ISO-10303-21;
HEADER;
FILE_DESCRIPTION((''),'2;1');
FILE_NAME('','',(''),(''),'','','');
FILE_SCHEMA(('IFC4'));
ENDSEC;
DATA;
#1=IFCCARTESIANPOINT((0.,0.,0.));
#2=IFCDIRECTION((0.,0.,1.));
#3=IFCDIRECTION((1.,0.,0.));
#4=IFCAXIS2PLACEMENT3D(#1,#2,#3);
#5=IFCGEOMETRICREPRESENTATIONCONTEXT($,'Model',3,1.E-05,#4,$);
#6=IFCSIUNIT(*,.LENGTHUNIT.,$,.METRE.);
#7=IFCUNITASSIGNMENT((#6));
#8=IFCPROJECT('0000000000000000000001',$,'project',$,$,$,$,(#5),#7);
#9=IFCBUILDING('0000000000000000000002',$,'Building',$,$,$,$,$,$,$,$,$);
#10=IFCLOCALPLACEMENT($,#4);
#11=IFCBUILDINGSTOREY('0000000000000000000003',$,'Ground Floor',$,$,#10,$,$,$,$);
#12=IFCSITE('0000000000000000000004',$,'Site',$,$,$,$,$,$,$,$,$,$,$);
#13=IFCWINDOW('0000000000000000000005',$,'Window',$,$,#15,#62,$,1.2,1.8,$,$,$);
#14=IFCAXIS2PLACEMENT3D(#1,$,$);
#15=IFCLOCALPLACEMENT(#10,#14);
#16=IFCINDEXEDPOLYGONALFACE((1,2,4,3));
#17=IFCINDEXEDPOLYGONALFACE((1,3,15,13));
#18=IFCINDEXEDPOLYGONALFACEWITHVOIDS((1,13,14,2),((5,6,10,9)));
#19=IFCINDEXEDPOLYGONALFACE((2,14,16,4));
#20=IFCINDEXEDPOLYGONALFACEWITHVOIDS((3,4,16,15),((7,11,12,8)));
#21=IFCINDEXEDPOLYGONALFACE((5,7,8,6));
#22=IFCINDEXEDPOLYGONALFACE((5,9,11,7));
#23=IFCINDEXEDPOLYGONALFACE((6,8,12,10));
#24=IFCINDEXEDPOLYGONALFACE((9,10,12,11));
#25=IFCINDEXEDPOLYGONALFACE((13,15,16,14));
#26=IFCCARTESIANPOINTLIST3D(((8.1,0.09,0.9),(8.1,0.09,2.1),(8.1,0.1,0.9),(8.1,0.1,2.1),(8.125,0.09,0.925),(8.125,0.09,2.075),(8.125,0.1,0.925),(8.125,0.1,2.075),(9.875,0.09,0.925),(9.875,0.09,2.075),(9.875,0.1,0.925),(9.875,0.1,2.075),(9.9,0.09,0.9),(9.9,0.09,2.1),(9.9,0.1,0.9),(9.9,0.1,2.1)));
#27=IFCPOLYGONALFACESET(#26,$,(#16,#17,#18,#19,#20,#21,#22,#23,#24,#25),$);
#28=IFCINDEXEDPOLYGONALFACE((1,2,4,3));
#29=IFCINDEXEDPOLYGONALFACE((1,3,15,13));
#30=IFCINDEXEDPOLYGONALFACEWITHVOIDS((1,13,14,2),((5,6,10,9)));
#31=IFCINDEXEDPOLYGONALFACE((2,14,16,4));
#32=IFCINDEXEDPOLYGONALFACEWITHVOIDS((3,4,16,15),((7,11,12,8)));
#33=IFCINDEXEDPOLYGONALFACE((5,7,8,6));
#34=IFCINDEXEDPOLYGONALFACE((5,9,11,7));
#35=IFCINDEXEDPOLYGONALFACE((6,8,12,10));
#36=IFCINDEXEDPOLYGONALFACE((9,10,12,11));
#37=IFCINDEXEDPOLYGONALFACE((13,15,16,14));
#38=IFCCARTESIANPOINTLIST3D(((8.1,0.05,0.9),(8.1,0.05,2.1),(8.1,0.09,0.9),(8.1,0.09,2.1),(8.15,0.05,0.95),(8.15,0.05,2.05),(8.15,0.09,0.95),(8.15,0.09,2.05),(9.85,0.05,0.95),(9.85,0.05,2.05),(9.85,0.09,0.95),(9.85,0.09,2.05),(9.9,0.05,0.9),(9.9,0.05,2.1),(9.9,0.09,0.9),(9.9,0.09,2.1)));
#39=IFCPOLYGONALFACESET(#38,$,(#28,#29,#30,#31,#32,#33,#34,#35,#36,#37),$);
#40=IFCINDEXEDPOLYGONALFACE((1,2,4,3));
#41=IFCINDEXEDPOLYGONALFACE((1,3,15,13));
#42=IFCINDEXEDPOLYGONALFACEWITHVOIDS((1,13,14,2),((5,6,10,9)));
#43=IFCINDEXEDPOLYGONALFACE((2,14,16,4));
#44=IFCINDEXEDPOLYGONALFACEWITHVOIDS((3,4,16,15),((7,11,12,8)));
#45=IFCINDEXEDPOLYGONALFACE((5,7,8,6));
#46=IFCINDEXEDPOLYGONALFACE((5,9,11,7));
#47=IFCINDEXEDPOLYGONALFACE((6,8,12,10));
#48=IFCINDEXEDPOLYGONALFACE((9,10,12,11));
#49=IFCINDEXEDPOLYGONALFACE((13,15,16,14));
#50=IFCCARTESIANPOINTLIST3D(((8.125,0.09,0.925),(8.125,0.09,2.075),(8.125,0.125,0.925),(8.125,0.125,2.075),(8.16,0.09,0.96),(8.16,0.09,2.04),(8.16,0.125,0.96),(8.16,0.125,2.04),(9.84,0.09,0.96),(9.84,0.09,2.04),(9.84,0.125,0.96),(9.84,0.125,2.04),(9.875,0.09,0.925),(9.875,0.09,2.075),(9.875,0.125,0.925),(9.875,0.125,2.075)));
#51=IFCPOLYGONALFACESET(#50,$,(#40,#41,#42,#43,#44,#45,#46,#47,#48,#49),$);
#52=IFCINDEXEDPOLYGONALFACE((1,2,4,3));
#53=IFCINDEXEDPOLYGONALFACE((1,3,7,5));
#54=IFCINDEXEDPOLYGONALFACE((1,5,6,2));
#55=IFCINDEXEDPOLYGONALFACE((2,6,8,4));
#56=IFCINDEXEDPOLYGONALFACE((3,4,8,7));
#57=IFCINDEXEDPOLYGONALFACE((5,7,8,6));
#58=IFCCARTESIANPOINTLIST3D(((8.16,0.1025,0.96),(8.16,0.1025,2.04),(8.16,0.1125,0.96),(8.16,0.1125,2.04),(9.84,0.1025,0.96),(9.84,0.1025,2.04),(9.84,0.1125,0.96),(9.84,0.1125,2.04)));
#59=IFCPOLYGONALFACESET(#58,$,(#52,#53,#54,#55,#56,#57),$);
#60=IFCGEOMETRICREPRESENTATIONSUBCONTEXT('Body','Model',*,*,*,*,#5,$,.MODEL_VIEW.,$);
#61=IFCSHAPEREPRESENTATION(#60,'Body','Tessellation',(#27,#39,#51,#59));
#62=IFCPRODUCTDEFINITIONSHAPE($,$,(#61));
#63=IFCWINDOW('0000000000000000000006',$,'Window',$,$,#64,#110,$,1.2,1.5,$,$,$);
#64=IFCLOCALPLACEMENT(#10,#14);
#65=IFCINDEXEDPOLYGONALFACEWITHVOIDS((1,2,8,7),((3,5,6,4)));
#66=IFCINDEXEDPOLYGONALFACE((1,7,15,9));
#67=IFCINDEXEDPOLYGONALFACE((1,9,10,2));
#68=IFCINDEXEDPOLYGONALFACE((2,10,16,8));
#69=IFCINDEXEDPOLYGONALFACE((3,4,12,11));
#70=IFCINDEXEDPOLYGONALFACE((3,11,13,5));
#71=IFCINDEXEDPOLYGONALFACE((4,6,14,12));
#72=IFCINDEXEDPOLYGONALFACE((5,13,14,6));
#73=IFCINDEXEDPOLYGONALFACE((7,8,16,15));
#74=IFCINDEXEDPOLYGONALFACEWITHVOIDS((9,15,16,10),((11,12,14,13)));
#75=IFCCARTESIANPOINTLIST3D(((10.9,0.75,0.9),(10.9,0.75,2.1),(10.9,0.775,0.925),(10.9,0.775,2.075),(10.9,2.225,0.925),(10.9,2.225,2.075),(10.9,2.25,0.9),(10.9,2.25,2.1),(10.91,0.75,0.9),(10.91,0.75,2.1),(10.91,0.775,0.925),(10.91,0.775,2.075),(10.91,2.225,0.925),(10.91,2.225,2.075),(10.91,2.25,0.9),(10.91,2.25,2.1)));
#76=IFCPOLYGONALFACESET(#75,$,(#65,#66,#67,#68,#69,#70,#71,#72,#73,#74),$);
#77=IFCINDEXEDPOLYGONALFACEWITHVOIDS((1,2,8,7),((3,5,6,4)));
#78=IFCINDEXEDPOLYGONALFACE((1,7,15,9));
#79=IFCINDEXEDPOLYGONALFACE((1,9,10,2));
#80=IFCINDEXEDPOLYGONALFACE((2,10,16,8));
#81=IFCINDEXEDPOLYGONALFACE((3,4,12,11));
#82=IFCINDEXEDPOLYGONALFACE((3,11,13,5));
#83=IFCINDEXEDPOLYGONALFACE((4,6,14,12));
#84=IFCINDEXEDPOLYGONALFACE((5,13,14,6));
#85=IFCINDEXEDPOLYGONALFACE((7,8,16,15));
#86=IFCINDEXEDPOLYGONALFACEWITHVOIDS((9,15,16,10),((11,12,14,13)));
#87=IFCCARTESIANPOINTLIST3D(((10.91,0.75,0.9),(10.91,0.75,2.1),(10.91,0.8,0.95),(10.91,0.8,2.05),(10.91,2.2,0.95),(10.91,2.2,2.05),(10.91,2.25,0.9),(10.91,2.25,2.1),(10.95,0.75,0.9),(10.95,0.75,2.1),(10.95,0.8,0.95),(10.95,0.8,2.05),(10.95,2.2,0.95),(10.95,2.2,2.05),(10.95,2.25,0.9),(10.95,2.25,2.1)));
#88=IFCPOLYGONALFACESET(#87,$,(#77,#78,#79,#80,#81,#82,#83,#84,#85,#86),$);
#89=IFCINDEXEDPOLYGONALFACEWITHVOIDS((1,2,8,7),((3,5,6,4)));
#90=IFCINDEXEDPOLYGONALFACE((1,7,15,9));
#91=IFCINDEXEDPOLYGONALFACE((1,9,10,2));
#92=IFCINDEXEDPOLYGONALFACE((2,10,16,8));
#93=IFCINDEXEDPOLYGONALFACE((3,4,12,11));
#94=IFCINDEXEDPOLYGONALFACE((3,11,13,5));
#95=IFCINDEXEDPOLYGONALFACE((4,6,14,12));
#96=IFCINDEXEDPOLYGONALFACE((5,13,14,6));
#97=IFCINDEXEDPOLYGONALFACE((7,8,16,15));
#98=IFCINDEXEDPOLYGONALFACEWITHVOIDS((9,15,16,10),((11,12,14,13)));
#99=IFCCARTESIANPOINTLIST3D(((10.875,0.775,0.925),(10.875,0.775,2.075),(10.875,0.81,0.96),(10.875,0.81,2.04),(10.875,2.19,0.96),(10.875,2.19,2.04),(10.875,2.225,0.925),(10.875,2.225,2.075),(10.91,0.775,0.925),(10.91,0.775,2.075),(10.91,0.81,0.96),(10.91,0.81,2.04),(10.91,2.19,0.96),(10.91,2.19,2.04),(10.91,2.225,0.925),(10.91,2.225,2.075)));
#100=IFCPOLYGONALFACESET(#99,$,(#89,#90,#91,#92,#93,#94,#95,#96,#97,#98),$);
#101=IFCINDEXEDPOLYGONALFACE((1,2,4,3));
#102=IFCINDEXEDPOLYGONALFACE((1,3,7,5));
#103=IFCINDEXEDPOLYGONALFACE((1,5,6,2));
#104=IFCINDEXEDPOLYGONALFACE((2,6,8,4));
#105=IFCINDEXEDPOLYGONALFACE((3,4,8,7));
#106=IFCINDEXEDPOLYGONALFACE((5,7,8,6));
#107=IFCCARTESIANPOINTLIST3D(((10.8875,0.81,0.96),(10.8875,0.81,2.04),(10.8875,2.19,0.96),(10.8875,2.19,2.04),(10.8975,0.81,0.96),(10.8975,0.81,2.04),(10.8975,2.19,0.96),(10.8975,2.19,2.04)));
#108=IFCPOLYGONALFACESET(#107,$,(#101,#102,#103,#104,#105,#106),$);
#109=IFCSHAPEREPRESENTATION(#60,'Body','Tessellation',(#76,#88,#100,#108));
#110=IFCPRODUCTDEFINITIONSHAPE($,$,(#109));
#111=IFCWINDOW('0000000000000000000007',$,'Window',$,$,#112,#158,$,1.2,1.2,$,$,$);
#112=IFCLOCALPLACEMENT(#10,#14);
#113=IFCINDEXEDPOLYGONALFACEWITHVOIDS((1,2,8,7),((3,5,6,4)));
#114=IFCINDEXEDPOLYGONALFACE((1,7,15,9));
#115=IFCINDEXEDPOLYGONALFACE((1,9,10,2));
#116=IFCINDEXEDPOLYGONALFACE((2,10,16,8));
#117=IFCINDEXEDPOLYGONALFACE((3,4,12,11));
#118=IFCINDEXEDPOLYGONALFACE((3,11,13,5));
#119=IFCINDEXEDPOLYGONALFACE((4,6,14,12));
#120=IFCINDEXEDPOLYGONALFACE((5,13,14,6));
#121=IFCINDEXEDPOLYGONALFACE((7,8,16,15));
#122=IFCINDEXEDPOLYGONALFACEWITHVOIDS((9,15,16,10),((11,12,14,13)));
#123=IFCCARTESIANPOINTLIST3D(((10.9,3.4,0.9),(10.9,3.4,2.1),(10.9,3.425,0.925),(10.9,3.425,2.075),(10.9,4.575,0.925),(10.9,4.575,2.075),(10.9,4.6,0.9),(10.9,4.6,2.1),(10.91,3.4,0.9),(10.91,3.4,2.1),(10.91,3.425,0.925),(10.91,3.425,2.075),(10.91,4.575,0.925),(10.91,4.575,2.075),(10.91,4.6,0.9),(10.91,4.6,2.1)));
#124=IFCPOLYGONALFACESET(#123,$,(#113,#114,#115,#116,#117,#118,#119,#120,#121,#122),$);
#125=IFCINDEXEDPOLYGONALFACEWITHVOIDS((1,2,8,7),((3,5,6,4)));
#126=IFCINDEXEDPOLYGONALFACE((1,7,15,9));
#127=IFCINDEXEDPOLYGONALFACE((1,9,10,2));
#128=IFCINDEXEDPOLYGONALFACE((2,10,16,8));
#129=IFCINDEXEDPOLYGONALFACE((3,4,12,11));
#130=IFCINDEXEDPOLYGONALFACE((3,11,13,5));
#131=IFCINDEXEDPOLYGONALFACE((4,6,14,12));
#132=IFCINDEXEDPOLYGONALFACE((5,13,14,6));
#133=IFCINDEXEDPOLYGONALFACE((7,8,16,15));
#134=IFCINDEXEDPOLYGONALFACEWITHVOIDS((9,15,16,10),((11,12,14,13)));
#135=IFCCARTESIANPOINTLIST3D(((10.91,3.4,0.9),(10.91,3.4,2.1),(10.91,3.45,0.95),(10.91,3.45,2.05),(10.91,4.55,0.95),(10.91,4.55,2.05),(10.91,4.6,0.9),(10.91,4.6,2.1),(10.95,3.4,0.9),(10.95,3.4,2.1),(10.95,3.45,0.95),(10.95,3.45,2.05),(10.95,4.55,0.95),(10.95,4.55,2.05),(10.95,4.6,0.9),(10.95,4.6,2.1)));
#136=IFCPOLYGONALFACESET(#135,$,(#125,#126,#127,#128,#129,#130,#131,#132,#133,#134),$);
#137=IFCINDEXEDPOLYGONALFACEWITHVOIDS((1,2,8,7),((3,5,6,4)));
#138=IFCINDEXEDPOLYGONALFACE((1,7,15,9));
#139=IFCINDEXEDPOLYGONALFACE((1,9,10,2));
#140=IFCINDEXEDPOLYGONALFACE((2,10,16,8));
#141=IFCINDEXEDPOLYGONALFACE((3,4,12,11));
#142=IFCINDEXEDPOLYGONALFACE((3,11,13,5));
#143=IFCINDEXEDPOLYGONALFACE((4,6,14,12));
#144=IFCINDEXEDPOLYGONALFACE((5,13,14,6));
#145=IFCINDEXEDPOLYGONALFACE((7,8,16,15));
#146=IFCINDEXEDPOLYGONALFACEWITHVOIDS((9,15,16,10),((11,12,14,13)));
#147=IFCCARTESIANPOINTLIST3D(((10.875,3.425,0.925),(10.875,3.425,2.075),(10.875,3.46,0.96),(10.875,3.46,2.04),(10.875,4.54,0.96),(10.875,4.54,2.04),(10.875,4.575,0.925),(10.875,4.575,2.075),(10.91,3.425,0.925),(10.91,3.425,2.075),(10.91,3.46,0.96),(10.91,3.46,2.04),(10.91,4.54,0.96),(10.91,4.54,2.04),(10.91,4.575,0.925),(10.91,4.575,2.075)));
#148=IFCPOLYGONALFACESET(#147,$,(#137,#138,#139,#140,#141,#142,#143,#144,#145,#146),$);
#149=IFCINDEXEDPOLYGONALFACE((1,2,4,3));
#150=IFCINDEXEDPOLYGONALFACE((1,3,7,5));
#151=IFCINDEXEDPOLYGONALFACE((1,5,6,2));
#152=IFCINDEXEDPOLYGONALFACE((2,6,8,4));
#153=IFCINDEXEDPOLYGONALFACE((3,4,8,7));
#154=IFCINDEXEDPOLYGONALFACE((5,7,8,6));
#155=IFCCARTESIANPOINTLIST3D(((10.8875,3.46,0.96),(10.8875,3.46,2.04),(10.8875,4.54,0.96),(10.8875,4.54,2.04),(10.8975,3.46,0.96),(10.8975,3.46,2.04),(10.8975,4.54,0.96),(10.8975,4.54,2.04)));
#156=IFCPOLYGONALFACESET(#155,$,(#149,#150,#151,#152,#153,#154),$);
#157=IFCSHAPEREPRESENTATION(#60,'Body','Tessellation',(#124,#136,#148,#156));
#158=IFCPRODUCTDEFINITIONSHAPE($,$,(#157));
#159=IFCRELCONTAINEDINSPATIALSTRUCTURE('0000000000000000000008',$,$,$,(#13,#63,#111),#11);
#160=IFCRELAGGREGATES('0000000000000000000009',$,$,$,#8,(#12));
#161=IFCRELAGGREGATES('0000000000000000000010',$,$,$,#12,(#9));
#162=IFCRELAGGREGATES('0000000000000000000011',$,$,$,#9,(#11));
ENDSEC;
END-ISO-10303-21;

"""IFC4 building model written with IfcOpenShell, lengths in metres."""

from ifc_helpers import new_model, si_unit, frame, origin_with_axes, place, context, subcontext, project, spatial, line, indexed_curve, outline, extrude, element, save


model = new_model("IFC4")

# Units and contexts
model_context = context("Model", 3, precision=1e-05, world=origin_with_axes())
body_context = subcontext(model_context, "Body", "Model", "MODEL_VIEW")
ifc_project = project(units=[si_unit("LENGTHUNIT", "METRE")], contexts=[model_context])

# Site, building, storey
site = spatial("IfcSite", under=ifc_project, Name="Site")
building = spatial("IfcBuilding", under=site, Name="Building")
storey_placement = place(None, origin_with_axes())
storey = spatial("IfcBuildingStorey", under=building, at=storey_placement, Name="Ground Floor")

# Windows
window_1_placement = place(storey_placement, frame((8.1, 0.0, 0.9), z_axis=(0.0, 0.0, 1.0), x_axis=(1.0, 0.0, 0.0)))
element("IfcWindow", 1, at=window_1_placement, inside=storey, Name="Window", OverallHeight=1.2, OverallWidth=1.8, context=body_context, shape_type="SweptSolid", body=[
    extrude(outline(indexed_curve([(0.0, 0.0), (1.8, 0.0), (1.8, 1.2), (0.0, 1.2)], segments=[line(1, 2, 3, 4, 1)]), holes=[indexed_curve([(0.025, 0.025), (1.775, 0.025), (1.775, 1.175), (0.025, 1.175)], segments=[line(1, 2, 3, 4, 1)])]), frame((0.0, 0.09, 0.0), z_axis=(0.0, -1.0, 0.0), x_axis=(1.0, 0.0, 0.0)), (0.0, 0.0, -1.0), 0.01),
    extrude(outline(indexed_curve([(0.0, 0.0), (1.8, 0.0), (1.8, 1.2), (0.0, 1.2)], segments=[line(1, 2, 3, 4, 1)]), holes=[indexed_curve([(0.05, 0.05), (1.75, 0.05), (1.75, 1.15), (0.05, 1.15)], segments=[line(1, 2, 3, 4, 1)])]), frame((0.0, 0.05, 0.0), z_axis=(0.0, -1.0, 0.0), x_axis=(1.0, 0.0, 0.0)), (0.0, 0.0, -1.0), 0.04),
    extrude(outline(indexed_curve([(0.0, 0.0), (1.75, 0.0), (1.75, 1.15), (0.0, 1.15)], segments=[line(1, 2, 3, 4, 1)]), holes=[indexed_curve([(0.035, 0.035), (1.715, 0.035), (1.715, 1.115), (0.035, 1.115)], segments=[line(1, 2, 3, 4, 1)])]), frame((0.025, 0.09, 0.025), z_axis=(0.0, -1.0, 0.0), x_axis=(1.0, 0.0, 0.0)), (0.0, 0.0, -1.0), 0.035),
    extrude(outline(indexed_curve([(0.035, 0.035), (1.715, 0.035), (1.715, 1.115), (0.035, 1.115)], segments=[line(1, 2, 3, 4, 1)])), frame((0.025, 0.1025, 0.025), z_axis=(0.0, -1.0, 0.0), x_axis=(1.0, 0.0, 0.0)), (0.0, 0.0, -1.0), 0.01),
])
window_2_placement = place(storey_placement, frame((11.0, 0.75, 0.9), z_axis=(0.0, 0.0, 1.0), x_axis=(0.0, 1.0, 0.0)))
element("IfcWindow", 2, at=window_2_placement, inside=storey, Name="Window", OverallHeight=1.2, OverallWidth=1.5, context=body_context, shape_type="SweptSolid", body=[
    extrude(outline(indexed_curve([(0.0, 0.0), (1.5, 0.0), (1.5, 1.2), (0.0, 1.2)], segments=[line(1, 2, 3, 4, 1)]), holes=[indexed_curve([(0.025, 0.025), (1.475, 0.025), (1.475, 1.175), (0.025, 1.175)], segments=[line(1, 2, 3, 4, 1)])]), frame((0.0, 0.09, 0.0), z_axis=(0.0, -1.0, 0.0), x_axis=(1.0, 0.0, 0.0)), (0.0, 0.0, -1.0), 0.01),
    extrude(outline(indexed_curve([(0.0, 0.0), (1.5, 0.0), (1.5, 1.2), (0.0, 1.2)], segments=[line(1, 2, 3, 4, 1)]), holes=[indexed_curve([(0.05, 0.05), (1.45, 0.05), (1.45, 1.15), (0.05, 1.15)], segments=[line(1, 2, 3, 4, 1)])]), frame((0.0, 0.05, 0.0), z_axis=(0.0, -1.0, 0.0), x_axis=(1.0, 0.0, 0.0)), (0.0, 0.0, -1.0), 0.04),
    extrude(outline(indexed_curve([(0.0, 0.0), (1.45, 0.0), (1.45, 1.15), (0.0, 1.15)], segments=[line(1, 2, 3, 4, 1)]), holes=[indexed_curve([(0.035, 0.035), (1.415, 0.035), (1.415, 1.115), (0.035, 1.115)], segments=[line(1, 2, 3, 4, 1)])]), frame((0.025, 0.09, 0.025), z_axis=(0.0, -1.0, 0.0), x_axis=(1.0, 0.0, 0.0)), (0.0, 0.0, -1.0), 0.035),
    extrude(outline(indexed_curve([(0.035, 0.035), (1.415, 0.035), (1.415, 1.115), (0.035, 1.115)], segments=[line(1, 2, 3, 4, 1)])), frame((0.025, 0.1025, 0.025), z_axis=(0.0, -1.0, 0.0), x_axis=(1.0, 0.0, 0.0)), (0.0, 0.0, -1.0), 0.01),
])
window_3_placement = place(storey_placement, frame((11.0, 3.4, 0.9), z_axis=(0.0, 0.0, 1.0), x_axis=(0.0, 1.0, 0.0)))
element("IfcWindow", 3, at=window_3_placement, inside=storey, Name="Window", OverallHeight=1.2, OverallWidth=1.2, context=body_context, shape_type="SweptSolid", body=[
    extrude(outline(indexed_curve([(0.0, 0.0), (1.2, 0.0), (1.2, 1.2), (0.0, 1.2)], segments=[line(1, 2, 3, 4, 1)]), holes=[indexed_curve([(0.025, 0.025), (1.175, 0.025), (1.175, 1.175), (0.025, 1.175)], segments=[line(1, 2, 3, 4, 1)])]), frame((0.0, 0.09, 0.0), z_axis=(0.0, -1.0, 0.0), x_axis=(1.0, 0.0, 0.0)), (0.0, 0.0, -1.0), 0.01),
    extrude(outline(indexed_curve([(0.0, 0.0), (1.2, 0.0), (1.2, 1.2), (0.0, 1.2)], segments=[line(1, 2, 3, 4, 1)]), holes=[indexed_curve([(0.05, 0.05), (1.15, 0.05), (1.15, 1.15), (0.05, 1.15)], segments=[line(1, 2, 3, 4, 1)])]), frame((0.0, 0.05, 0.0), z_axis=(0.0, -1.0, 0.0), x_axis=(1.0, 0.0, 0.0)), (0.0, 0.0, -1.0), 0.04),
    extrude(outline(indexed_curve([(0.0, 0.0), (1.15, 0.0), (1.15, 1.15), (0.0, 1.15)], segments=[line(1, 2, 3, 4, 1)]), holes=[indexed_curve([(0.035, 0.035), (1.115, 0.035), (1.115, 1.115), (0.035, 1.115)], segments=[line(1, 2, 3, 4, 1)])]), frame((0.025, 0.09, 0.025), z_axis=(0.0, -1.0, 0.0), x_axis=(1.0, 0.0, 0.0)), (0.0, 0.0, -1.0), 0.035),
    extrude(outline(indexed_curve([(0.035, 0.035), (1.115, 0.035), (1.115, 1.115), (0.035, 1.115)], segments=[line(1, 2, 3, 4, 1)])), frame((0.025, 0.1025, 0.025), z_axis=(0.0, -1.0, 0.0), x_axis=(1.0, 0.0, 0.0)), (0.0, 0.0, -1.0), 0.01),
])

save(model, "model.ifc")
